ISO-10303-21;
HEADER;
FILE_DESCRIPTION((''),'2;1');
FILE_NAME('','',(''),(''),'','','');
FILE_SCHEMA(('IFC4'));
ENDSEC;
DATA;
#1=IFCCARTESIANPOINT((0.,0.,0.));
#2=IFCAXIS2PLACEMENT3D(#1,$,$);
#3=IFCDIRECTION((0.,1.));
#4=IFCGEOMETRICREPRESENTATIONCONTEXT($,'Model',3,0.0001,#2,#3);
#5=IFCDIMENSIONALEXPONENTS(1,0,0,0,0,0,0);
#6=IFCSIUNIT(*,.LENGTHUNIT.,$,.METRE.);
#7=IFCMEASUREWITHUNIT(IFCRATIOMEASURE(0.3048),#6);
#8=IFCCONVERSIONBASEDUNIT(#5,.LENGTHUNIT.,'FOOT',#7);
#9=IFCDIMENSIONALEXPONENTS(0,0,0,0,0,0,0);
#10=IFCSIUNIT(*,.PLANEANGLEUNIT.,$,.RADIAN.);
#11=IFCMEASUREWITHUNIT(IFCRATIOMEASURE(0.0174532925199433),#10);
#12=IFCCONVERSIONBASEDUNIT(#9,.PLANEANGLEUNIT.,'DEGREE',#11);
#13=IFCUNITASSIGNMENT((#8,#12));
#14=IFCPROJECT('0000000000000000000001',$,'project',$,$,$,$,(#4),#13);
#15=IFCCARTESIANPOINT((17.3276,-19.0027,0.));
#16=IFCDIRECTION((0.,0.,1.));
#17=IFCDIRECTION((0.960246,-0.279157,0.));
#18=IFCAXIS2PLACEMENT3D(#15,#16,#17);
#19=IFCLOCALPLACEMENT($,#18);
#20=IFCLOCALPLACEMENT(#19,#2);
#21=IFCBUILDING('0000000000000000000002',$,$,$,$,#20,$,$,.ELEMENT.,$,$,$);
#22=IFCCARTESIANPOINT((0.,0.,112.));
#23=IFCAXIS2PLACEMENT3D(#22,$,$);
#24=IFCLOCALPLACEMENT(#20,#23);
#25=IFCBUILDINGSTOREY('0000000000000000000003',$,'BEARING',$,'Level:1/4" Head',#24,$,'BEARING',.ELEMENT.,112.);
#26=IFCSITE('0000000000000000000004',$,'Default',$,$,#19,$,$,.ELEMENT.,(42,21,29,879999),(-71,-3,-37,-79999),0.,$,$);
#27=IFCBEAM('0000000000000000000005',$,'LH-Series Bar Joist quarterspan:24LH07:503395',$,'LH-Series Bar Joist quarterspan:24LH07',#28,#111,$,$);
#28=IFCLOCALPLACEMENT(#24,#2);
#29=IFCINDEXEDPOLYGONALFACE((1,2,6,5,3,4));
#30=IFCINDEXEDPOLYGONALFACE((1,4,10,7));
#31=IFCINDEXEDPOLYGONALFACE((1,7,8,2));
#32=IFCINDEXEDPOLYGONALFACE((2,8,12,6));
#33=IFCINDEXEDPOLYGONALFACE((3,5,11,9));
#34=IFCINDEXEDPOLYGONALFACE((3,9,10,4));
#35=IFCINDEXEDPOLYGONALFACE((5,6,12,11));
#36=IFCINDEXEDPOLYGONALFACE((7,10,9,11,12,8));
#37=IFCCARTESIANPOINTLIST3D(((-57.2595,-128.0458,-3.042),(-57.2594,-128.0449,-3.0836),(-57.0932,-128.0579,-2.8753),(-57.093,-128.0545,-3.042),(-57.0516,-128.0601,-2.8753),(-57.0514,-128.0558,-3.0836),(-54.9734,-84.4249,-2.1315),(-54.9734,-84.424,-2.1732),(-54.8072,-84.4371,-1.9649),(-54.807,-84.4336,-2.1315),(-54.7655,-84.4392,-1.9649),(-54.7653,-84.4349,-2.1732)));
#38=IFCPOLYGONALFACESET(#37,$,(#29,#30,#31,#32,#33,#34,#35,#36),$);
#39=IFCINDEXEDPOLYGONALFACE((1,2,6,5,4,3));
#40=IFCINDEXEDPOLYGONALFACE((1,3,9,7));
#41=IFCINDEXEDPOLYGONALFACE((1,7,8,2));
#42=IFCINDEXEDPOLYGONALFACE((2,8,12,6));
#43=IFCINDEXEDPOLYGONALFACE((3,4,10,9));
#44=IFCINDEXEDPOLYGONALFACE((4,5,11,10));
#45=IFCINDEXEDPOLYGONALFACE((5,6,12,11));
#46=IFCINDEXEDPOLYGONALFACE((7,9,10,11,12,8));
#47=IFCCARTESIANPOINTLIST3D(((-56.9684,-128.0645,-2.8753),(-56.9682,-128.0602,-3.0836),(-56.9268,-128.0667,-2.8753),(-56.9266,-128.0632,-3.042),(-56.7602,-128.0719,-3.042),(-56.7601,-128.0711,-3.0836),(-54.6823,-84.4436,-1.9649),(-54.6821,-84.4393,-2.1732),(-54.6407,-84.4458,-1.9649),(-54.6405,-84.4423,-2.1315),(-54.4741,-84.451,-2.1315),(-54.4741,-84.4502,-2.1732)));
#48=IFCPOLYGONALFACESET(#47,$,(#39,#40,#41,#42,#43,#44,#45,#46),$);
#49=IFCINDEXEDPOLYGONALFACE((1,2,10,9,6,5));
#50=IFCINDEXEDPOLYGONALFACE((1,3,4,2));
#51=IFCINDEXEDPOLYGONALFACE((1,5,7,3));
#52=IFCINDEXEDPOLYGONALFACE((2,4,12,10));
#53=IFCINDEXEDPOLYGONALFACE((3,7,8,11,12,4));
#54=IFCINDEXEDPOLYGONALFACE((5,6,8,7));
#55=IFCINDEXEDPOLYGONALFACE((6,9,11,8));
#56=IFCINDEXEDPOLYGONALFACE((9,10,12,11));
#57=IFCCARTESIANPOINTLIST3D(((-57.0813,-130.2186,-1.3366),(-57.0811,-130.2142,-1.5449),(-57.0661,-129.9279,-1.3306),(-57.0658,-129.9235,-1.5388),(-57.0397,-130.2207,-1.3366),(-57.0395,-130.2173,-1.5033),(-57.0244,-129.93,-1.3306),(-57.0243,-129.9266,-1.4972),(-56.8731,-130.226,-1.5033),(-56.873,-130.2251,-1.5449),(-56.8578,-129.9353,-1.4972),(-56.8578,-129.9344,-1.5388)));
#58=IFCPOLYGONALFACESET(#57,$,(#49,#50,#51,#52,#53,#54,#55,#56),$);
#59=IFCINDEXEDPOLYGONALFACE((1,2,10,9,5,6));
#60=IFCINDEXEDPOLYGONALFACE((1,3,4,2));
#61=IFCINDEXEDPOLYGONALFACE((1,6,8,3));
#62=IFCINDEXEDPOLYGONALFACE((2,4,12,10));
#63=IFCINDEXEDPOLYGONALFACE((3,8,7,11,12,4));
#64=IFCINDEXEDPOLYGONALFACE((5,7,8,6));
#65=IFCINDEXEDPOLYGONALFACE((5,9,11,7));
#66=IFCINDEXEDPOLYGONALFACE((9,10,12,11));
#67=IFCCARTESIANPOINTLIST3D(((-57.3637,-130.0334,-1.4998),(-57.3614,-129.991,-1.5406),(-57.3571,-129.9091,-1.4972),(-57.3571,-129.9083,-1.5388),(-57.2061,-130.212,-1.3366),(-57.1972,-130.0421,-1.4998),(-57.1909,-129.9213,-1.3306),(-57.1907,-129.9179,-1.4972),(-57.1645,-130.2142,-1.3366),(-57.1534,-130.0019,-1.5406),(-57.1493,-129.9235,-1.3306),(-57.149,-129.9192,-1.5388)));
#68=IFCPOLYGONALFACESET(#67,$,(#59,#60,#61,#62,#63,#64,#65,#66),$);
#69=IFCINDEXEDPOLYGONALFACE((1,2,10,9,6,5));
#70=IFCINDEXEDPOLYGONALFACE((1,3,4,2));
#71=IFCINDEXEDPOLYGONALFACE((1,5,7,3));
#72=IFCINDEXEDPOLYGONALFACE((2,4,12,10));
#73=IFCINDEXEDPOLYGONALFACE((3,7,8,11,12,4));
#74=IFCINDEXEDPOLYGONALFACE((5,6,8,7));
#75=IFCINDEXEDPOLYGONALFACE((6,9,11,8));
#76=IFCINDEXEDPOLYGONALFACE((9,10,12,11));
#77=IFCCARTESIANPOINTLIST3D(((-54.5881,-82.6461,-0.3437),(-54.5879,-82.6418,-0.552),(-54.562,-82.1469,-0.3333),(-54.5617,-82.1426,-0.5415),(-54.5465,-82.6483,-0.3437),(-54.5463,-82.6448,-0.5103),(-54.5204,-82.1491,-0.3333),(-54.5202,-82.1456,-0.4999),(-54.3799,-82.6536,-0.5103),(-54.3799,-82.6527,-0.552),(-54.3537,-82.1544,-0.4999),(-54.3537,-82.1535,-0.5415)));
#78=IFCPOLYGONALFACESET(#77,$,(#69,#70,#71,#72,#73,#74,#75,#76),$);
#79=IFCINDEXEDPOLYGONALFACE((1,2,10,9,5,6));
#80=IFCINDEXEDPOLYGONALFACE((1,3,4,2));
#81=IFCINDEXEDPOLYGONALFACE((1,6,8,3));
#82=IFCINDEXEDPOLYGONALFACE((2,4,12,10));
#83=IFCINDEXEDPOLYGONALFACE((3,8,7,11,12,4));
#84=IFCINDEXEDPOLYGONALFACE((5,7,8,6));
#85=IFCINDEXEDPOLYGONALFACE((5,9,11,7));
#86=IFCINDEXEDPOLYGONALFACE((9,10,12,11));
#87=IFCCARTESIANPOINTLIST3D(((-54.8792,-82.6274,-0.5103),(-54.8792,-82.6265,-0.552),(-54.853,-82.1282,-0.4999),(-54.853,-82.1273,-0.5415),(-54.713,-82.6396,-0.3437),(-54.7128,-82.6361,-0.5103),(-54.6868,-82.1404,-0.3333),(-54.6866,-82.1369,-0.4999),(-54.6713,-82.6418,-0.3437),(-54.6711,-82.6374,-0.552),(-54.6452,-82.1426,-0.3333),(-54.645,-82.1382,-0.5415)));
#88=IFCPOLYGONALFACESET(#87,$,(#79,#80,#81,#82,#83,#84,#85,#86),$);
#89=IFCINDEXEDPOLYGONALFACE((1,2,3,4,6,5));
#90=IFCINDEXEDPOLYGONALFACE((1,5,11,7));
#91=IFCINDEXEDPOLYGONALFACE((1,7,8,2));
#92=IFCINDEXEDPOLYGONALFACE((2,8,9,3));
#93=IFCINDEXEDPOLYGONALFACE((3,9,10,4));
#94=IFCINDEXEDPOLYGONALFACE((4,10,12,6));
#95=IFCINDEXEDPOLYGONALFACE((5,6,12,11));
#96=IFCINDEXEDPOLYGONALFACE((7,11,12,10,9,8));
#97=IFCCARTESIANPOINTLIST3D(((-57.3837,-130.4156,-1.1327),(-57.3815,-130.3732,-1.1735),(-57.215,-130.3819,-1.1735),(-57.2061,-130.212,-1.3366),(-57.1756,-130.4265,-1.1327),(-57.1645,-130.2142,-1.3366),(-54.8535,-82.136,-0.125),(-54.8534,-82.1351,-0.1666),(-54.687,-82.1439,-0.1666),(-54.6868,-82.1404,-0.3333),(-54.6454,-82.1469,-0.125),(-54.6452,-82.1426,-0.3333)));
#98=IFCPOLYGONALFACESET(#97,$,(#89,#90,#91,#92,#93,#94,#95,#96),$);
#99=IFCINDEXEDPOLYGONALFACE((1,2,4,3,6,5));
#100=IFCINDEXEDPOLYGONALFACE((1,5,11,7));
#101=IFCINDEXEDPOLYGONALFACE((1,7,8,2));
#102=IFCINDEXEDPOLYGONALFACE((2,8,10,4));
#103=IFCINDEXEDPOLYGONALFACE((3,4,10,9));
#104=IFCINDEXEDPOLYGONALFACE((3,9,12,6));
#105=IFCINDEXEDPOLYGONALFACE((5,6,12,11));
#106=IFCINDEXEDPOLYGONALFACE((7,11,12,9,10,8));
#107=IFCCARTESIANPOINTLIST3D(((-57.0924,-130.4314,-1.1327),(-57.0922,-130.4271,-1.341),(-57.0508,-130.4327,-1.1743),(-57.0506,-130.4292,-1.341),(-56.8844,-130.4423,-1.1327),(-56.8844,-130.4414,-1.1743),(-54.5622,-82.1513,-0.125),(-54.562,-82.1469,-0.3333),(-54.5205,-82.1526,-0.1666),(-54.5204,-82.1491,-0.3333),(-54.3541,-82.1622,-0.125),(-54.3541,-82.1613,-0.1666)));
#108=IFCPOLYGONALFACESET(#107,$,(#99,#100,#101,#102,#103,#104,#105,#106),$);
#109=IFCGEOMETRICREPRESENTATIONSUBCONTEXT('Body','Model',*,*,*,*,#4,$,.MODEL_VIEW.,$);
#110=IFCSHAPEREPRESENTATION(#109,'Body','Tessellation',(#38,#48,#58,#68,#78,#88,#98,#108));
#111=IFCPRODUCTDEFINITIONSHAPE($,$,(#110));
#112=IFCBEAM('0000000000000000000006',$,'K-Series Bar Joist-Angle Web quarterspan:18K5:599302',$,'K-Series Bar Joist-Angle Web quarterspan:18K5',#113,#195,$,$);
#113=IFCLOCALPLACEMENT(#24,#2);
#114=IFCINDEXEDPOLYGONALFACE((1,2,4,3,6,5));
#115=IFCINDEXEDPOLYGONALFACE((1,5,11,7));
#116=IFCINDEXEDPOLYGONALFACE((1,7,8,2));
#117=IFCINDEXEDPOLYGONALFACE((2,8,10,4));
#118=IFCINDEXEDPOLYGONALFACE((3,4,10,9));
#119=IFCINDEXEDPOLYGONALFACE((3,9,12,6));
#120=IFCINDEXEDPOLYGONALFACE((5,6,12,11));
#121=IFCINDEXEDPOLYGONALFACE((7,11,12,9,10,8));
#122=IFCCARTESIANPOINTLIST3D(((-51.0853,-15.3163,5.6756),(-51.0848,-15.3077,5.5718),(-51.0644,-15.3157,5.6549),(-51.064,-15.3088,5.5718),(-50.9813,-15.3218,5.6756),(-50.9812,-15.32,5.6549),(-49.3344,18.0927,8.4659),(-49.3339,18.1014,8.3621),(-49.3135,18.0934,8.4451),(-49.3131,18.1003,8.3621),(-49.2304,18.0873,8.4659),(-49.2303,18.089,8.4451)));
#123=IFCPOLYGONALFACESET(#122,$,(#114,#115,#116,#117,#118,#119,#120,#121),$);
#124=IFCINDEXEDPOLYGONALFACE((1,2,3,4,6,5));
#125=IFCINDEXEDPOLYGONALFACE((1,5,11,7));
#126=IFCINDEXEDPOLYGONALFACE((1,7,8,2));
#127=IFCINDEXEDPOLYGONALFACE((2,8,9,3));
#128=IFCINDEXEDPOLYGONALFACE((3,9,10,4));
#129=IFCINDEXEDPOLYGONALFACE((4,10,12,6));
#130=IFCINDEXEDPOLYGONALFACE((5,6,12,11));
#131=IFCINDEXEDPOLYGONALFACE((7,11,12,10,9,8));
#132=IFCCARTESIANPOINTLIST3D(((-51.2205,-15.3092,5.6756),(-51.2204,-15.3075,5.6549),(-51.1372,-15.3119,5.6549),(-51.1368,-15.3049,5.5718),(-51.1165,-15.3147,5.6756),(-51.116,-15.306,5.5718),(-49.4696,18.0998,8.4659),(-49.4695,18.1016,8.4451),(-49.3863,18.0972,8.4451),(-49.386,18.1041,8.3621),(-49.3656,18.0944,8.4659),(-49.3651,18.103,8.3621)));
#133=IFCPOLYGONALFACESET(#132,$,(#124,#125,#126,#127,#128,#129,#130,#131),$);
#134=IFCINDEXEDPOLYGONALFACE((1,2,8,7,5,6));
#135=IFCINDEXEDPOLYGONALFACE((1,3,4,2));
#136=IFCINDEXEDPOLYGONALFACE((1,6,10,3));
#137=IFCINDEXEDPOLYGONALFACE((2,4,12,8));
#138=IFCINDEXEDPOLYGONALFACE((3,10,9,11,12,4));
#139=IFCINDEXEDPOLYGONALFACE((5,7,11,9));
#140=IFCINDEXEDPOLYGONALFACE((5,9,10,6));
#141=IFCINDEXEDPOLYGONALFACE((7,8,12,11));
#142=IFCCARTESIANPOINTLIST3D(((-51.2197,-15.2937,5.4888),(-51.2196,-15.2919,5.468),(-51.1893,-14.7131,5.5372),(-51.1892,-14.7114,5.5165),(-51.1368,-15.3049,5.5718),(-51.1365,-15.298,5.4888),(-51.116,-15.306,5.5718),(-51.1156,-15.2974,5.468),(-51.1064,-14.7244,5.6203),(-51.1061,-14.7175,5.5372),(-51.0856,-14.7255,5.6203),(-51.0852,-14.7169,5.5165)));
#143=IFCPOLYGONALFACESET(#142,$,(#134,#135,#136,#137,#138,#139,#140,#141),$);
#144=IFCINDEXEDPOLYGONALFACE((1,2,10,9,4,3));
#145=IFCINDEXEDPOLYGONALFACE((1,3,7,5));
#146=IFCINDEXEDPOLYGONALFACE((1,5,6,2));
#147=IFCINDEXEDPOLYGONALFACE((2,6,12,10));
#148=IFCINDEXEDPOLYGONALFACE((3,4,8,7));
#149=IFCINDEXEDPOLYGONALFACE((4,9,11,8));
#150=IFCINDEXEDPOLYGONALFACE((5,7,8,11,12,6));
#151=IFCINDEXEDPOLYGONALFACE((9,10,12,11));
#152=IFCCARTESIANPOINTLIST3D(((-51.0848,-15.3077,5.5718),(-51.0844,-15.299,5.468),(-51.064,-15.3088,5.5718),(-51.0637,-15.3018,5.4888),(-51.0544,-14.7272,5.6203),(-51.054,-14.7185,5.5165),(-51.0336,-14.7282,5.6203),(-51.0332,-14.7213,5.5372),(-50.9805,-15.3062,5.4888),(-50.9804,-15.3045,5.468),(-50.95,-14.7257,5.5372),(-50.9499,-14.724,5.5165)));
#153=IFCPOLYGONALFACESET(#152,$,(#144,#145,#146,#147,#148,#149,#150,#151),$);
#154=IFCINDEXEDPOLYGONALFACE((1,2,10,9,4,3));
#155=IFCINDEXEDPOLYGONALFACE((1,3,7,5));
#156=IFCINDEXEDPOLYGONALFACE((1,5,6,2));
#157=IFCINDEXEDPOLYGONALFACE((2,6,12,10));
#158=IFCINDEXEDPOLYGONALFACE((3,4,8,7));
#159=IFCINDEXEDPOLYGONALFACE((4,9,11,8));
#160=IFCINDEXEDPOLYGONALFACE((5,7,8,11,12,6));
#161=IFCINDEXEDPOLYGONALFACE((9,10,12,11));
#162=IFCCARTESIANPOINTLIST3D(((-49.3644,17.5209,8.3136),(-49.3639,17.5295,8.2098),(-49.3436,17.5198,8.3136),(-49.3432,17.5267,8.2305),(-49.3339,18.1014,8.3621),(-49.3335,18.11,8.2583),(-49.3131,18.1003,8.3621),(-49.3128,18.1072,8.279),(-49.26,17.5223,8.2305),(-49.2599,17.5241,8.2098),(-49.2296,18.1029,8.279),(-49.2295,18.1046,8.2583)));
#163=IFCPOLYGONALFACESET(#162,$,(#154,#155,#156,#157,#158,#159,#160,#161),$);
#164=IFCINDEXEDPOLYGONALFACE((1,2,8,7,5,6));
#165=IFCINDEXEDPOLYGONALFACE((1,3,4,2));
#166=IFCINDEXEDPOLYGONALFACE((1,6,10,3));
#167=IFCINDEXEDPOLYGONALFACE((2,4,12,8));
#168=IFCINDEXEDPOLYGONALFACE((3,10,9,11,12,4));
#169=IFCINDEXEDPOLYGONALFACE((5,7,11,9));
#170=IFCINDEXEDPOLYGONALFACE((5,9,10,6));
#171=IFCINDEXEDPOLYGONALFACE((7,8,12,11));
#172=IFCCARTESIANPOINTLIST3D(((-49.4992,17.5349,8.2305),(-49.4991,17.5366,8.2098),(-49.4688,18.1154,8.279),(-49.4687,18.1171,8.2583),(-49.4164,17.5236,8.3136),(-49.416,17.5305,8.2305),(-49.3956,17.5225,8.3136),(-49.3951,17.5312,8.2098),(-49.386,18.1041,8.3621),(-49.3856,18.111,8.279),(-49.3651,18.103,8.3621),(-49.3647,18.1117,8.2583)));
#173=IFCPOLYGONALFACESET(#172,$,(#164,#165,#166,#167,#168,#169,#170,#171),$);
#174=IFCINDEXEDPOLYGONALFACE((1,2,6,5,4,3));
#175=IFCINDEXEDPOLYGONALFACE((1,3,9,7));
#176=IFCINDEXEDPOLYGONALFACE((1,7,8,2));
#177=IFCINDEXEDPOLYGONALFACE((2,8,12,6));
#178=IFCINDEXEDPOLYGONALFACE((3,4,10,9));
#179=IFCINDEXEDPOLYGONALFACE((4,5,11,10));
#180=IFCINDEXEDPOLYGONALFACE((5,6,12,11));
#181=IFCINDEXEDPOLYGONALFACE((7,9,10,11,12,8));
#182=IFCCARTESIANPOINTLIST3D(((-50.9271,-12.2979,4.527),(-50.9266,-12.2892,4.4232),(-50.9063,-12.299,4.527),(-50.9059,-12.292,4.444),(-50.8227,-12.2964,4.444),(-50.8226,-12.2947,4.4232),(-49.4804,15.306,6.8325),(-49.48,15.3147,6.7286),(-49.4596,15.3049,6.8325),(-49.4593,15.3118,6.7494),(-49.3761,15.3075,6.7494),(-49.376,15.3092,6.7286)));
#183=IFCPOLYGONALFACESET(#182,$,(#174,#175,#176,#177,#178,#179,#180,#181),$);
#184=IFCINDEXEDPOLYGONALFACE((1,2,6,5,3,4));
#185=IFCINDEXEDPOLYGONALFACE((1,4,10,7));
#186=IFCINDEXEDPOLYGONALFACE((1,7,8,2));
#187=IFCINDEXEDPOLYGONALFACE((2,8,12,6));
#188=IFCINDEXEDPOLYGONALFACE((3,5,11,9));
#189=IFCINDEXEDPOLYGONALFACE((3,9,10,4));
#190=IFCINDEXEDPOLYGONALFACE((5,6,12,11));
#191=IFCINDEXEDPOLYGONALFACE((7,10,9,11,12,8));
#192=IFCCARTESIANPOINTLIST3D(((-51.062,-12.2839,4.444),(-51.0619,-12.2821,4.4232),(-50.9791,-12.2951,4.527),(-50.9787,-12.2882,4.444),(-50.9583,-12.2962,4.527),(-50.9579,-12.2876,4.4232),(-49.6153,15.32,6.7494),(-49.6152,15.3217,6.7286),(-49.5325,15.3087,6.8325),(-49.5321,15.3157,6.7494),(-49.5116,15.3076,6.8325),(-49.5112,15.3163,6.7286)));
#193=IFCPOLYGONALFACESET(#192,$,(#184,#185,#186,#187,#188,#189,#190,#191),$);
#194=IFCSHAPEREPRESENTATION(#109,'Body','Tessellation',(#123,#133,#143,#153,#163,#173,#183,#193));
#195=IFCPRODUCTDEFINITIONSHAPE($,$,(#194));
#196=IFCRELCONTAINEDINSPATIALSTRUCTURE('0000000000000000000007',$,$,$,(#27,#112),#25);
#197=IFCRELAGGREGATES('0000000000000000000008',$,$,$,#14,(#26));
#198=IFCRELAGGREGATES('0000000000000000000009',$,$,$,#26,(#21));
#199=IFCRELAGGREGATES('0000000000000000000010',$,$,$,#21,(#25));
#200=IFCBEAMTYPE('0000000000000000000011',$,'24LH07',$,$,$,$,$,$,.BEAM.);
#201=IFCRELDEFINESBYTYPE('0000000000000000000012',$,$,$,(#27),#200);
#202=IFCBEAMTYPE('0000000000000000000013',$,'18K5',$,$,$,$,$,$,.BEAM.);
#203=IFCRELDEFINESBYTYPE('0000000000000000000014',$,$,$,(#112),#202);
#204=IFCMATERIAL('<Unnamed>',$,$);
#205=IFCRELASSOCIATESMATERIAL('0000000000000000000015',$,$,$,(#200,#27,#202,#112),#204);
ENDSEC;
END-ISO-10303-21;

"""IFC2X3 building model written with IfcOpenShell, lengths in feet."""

from ifc_helpers import new_model, entity, si_unit, converted_unit, direction, frame, origin, place, context, subcontext, project, spatial, polyline, outline, extrude, clip, halfspace, source, transform, mapped, material, type_object, type_shapes, element, save


model = new_model("IFC2X3")

# Units and contexts
model_context = context("Model", 3, precision=0.0001, world=origin(), true_north=direction((0.0, 1.0)))
body_context = subcontext(model_context, "Body", "Model", "MODEL_VIEW")
ifc_project = project(units=[converted_unit("LENGTHUNIT", "FOOT", entity("IfcRatioMeasure", 0.3048), si_unit("LENGTHUNIT", "METRE"), dimensions=[1, 0, 0, 0, 0, 0, 0]), converted_unit("PLANEANGLEUNIT", "DEGREE", entity("IfcRatioMeasure", 0.0174532925199433), si_unit("PLANEANGLEUNIT", "RADIAN"), dimensions=[0, 0, 0, 0, 0, 0, 0])], contexts=[model_context])

# Site, building, storey
site_placement = place(None, frame((17.3276, -19.0027, 0.0), z_axis=(0.0, 0.0, 1.0), x_axis=(0.960246, -0.279157, 0.0)))
site = spatial("IfcSite", under=ifc_project, at=site_placement, Name="Default", CompositionType="ELEMENT", RefLatitude=(42, 21, 29, 879999), RefLongitude=(-71, -3, -37, -79999), RefElevation=0.0)
building_placement = place(site_placement, origin())
building = spatial("IfcBuilding", under=site, at=building_placement, CompositionType="ELEMENT")
storey_placement = place(building_placement, frame((0.0, 0.0, 112.0)))
storey = spatial("IfcBuildingStorey", under=building, at=storey_placement, Name="BEARING", ObjectType="Level:1/4\" Head", LongName="BEARING", CompositionType="ELEMENT", Elevation=112.0)

# Shared definitions
ifc_material_1 = material(Name="<Unnamed>")

# Beams
beam_type_1 = type_object("IfcBeamType", Name="24LH07", PredefinedType="BEAM", material=ifc_material_1)
shared_shape_1 = source(origin(), body_context, "Body", "SweptSolid", [
    extrude(outline(polyline([(-0.0833, -0.0833), (0.125, -0.0833), (0.125, -0.0417), (-0.0417, -0.0417), (-0.0417, 0.125), (-0.0833, 0.125), (-0.0833, -0.0833)])), frame((-54.8486, -84.4323, 109.9102), z_axis=(-0.052325, -0.998413, -0.020839), x_axis=(-0.001091, -0.020811, 0.999783)), (0.0, 0.0, 1.0), 43.6902),
    extrude(outline(polyline([(-0.125, -0.0417), (-0.125, -0.0833), (0.0833, -0.0833), (0.0833, 0.125), (0.0417, 0.125), (0.0417, -0.0417), (-0.125, -0.0417)])), frame((-54.599, -84.4454, 109.9102), z_axis=(0.052325, 0.998413, 0.020839), x_axis=(-0.99863, 0.052336, 0.0)), (0.0, 0.0, -1.0), 43.6902),
    extrude(outline(polyline([(-0.125, -0.0417), (-0.125, -0.0833), (0.0833, -0.0833), (0.0833, 0.125), (0.0417, 0.125), (0.0417, -0.0417), (-0.125, -0.0417)])), frame((-56.9827, -129.9296, 110.5445), z_axis=(0.052325, 0.998413, 0.020839), x_axis=(-0.99863, 0.052336, 0.0)), (0.0, 0.0, -1.0), 0.2912),
    clip(extrude(outline(polyline([(-0.0833, -0.0833), (0.125, -0.0833), (0.125, -0.0417), (-0.0417, -0.0417), (-0.0417, 0.125), (-0.0833, 0.125), (-0.0833, -0.0833)])), frame((-57.2324, -129.9165, 110.5445), z_axis=(-0.052325, -0.998413, -0.020839), x_axis=(-0.001091, -0.020811, 0.999783)), (0.0, 0.0, 1.0), 0.2912), halfspace(frame((-105.4247, -127.8984, 110.8678), z_axis=(-0.036228, -0.691277, -0.721682), x_axis=(0.99863, -0.052336, 0.0)), False)),
    extrude(outline(polyline([(-0.0833, -0.125), (-0.0417, -0.125), (-0.0417, 0.0417), (0.125, 0.0417), (0.125, 0.0833), (-0.0833, 0.0833), (-0.0833, -0.125)])), frame((-54.4786, -82.1487, 111.5418), z_axis=(-0.052325, -0.998413, -0.020839), x_axis=(-0.001091, -0.020811, 0.999783)), (0.0, 0.0, 1.0), 0.5),
    extrude(outline(polyline([(-0.0833, -0.0833), (0.125, -0.0833), (0.125, -0.0417), (-0.0417, -0.0417), (-0.0417, 0.125), (-0.0833, 0.125), (-0.0833, -0.0833)])), frame((-54.7283, -82.1356, 111.5418), z_axis=(-0.052325, -0.998413, -0.020839), x_axis=(-0.001091, -0.020811, 0.999783)), (0.0, 0.0, 1.0), 0.5),
    clip(extrude(outline(polyline([(-0.0833, -0.0833), (0.125, -0.0833), (0.125, -0.0416), (-0.0417, -0.0416), (-0.0417, 0.125), (-0.0833, 0.125), (-0.0833, -0.0833)])), frame((-54.7285, -82.1408, 111.7918), z_axis=(-0.052325, -0.998413, -0.020839), x_axis=(-0.99863, 0.052336, 0.0)), (0.0, 0.0, 1.0), 48.3569), halfspace(frame((-105.4247, -127.8984, 110.8678), z_axis=(-0.036228, -0.691277, -0.721682), x_axis=(0.99863, -0.052336, 0.0)), False)),
    extrude(outline(polyline([(-0.125, -0.0833), (0.0833, -0.0833), (0.0833, 0.125), (0.0417, 0.125), (0.0417, -0.0416), (-0.125, -0.0416), (-0.125, -0.0833)])), frame((-54.4789, -82.1539, 111.7918), z_axis=(-0.052325, -0.998413, -0.020839), x_axis=(-0.99863, 0.052336, 0.0)), (0.0, 0.0, 1.0), 48.3569),
])
type_shapes(beam_type_1, [shared_shape_1])
beam_1_placement = place(storey_placement, frame((0.0, 0.0, -112.0)))
element("IfcBeam", 1, at=beam_1_placement, inside=storey, type_object=beam_type_1, material=ifc_material_1, Name="LH-Series Bar Joist quarterspan:24LH07:503395", ObjectType="LH-Series Bar Joist quarterspan:24LH07", context=body_context, shape_type="MappedRepresentation", body=[
    mapped(shared_shape_1, transform((0.0, 0.0, 0.0), scale=1.0)),
])
beam_type_2 = type_object("IfcBeamType", Name="18K5", PredefinedType="BEAM", material=ifc_material_1)
shared_shape_2 = source(origin(), body_context, "Body", "SweptSolid", [
    extrude(outline(polyline([(-0.0417, -0.0625), (-0.0208, -0.0625), (-0.0208, 0.0208), (0.0625, 0.0208), (0.0625, 0.0417), (-0.0417, 0.0417), (-0.0417, -0.0625)])), frame((-16.7855, -0.0573, 0.7083), z_axis=(1.0, 0.0, 0.0), x_axis=(0.0, 0.0, -1.0)), (0.0, 0.0, 1.0), 33.5711),
    extrude(outline(polyline([(-0.0417, -0.0417), (0.0625, -0.0417), (0.0625, -0.0208), (-0.0208, -0.0208), (-0.0208, 0.0625), (-0.0417, 0.0625), (-0.0417, -0.0417)])), frame((-16.7855, 0.0573, 0.7083), z_axis=(1.0, 0.0, 0.0), x_axis=(0.0, 0.0, -1.0)), (0.0, 0.0, 1.0), 33.5711),
    extrude(outline(polyline([(-0.0625, -0.0417), (0.0417, -0.0417), (0.0417, 0.0625), (0.0208, 0.0625), (0.0208, -0.0208), (-0.0625, -0.0208), (-0.0625, -0.0417)])), frame((-16.7855, 0.0573, 0.5833), z_axis=(1.0, 0.0, 0.0), x_axis=(0.0, 0.0, -1.0)), (0.0, 0.0, 1.0), 0.5833),
    extrude(outline(polyline([(0.0208, -0.0625), (0.0417, -0.0625), (0.0417, 0.0417), (-0.0625, 0.0417), (-0.0625, 0.0208), (0.0208, 0.0208), (0.0208, -0.0625)])), frame((-16.7855, -0.0573, 0.5833), z_axis=(1.0, 0.0, 0.0), x_axis=(0.0, 0.0, -1.0)), (0.0, 0.0, 1.0), 0.5833),
    extrude(outline(polyline([(0.0208, -0.0625), (0.0417, -0.0625), (0.0417, 0.0417), (-0.0625, 0.0417), (-0.0625, 0.0208), (0.0208, 0.0208), (0.0208, -0.0625)])), frame((16.2022, -0.0573, 0.5833), z_axis=(1.0, 0.0, 0.0), x_axis=(0.0, 0.0, -1.0)), (0.0, 0.0, 1.0), 0.5833),
    extrude(outline(polyline([(-0.0625, -0.0417), (0.0417, -0.0417), (0.0417, 0.0625), (0.0208, 0.0625), (0.0208, -0.0208), (-0.0625, -0.0208), (-0.0625, -0.0417)])), frame((16.2022, 0.0573, 0.5833), z_axis=(1.0, 0.0, 0.0), x_axis=(0.0, 0.0, -1.0)), (0.0, 0.0, 1.0), 0.5833),
    extrude(outline(polyline([(0.0208, -0.0625), (0.0417, -0.0625), (0.0417, 0.0417), (-0.0625, 0.0417), (-0.0625, 0.0208), (0.0208, 0.0208), (0.0208, -0.0625)])), frame((-13.8689, -0.0573, -0.7083), z_axis=(1.0, 0.0, 0.0), x_axis=(0.0, 0.0, -1.0)), (0.0, 0.0, 1.0), 27.7377),
    extrude(outline(polyline([(-0.0625, -0.0417), (0.0417, -0.0417), (0.0417, 0.0625), (0.0208, 0.0625), (0.0208, -0.0208), (-0.0625, -0.0208), (-0.0625, -0.0417)])), frame((-13.8689, 0.0573, -0.7083), z_axis=(1.0, 0.0, 0.0), x_axis=(0.0, 0.0, -1.0)), (0.0, 0.0, 1.0), 27.7377),
])
type_shapes(beam_type_2, [shared_shape_2])
beam_2_placement = place(storey_placement, frame((-50.2222, 1.4513, 6.3233), z_axis=(-0.00435, -0.083001, 0.99654), x_axis=(0.052155, 0.995174, 0.083115)))
element("IfcBeam", 2, at=beam_2_placement, inside=storey, type_object=beam_type_2, material=ifc_material_1, Name="K-Series Bar Joist-Angle Web quarterspan:18K5:599302", ObjectType="K-Series Bar Joist-Angle Web quarterspan:18K5", context=body_context, shape_type="MappedRepresentation", body=[
    mapped(shared_shape_2, transform((0.0, 0.0, 0.0), scale=1.0)),
])

save(model, "model.ifc")
